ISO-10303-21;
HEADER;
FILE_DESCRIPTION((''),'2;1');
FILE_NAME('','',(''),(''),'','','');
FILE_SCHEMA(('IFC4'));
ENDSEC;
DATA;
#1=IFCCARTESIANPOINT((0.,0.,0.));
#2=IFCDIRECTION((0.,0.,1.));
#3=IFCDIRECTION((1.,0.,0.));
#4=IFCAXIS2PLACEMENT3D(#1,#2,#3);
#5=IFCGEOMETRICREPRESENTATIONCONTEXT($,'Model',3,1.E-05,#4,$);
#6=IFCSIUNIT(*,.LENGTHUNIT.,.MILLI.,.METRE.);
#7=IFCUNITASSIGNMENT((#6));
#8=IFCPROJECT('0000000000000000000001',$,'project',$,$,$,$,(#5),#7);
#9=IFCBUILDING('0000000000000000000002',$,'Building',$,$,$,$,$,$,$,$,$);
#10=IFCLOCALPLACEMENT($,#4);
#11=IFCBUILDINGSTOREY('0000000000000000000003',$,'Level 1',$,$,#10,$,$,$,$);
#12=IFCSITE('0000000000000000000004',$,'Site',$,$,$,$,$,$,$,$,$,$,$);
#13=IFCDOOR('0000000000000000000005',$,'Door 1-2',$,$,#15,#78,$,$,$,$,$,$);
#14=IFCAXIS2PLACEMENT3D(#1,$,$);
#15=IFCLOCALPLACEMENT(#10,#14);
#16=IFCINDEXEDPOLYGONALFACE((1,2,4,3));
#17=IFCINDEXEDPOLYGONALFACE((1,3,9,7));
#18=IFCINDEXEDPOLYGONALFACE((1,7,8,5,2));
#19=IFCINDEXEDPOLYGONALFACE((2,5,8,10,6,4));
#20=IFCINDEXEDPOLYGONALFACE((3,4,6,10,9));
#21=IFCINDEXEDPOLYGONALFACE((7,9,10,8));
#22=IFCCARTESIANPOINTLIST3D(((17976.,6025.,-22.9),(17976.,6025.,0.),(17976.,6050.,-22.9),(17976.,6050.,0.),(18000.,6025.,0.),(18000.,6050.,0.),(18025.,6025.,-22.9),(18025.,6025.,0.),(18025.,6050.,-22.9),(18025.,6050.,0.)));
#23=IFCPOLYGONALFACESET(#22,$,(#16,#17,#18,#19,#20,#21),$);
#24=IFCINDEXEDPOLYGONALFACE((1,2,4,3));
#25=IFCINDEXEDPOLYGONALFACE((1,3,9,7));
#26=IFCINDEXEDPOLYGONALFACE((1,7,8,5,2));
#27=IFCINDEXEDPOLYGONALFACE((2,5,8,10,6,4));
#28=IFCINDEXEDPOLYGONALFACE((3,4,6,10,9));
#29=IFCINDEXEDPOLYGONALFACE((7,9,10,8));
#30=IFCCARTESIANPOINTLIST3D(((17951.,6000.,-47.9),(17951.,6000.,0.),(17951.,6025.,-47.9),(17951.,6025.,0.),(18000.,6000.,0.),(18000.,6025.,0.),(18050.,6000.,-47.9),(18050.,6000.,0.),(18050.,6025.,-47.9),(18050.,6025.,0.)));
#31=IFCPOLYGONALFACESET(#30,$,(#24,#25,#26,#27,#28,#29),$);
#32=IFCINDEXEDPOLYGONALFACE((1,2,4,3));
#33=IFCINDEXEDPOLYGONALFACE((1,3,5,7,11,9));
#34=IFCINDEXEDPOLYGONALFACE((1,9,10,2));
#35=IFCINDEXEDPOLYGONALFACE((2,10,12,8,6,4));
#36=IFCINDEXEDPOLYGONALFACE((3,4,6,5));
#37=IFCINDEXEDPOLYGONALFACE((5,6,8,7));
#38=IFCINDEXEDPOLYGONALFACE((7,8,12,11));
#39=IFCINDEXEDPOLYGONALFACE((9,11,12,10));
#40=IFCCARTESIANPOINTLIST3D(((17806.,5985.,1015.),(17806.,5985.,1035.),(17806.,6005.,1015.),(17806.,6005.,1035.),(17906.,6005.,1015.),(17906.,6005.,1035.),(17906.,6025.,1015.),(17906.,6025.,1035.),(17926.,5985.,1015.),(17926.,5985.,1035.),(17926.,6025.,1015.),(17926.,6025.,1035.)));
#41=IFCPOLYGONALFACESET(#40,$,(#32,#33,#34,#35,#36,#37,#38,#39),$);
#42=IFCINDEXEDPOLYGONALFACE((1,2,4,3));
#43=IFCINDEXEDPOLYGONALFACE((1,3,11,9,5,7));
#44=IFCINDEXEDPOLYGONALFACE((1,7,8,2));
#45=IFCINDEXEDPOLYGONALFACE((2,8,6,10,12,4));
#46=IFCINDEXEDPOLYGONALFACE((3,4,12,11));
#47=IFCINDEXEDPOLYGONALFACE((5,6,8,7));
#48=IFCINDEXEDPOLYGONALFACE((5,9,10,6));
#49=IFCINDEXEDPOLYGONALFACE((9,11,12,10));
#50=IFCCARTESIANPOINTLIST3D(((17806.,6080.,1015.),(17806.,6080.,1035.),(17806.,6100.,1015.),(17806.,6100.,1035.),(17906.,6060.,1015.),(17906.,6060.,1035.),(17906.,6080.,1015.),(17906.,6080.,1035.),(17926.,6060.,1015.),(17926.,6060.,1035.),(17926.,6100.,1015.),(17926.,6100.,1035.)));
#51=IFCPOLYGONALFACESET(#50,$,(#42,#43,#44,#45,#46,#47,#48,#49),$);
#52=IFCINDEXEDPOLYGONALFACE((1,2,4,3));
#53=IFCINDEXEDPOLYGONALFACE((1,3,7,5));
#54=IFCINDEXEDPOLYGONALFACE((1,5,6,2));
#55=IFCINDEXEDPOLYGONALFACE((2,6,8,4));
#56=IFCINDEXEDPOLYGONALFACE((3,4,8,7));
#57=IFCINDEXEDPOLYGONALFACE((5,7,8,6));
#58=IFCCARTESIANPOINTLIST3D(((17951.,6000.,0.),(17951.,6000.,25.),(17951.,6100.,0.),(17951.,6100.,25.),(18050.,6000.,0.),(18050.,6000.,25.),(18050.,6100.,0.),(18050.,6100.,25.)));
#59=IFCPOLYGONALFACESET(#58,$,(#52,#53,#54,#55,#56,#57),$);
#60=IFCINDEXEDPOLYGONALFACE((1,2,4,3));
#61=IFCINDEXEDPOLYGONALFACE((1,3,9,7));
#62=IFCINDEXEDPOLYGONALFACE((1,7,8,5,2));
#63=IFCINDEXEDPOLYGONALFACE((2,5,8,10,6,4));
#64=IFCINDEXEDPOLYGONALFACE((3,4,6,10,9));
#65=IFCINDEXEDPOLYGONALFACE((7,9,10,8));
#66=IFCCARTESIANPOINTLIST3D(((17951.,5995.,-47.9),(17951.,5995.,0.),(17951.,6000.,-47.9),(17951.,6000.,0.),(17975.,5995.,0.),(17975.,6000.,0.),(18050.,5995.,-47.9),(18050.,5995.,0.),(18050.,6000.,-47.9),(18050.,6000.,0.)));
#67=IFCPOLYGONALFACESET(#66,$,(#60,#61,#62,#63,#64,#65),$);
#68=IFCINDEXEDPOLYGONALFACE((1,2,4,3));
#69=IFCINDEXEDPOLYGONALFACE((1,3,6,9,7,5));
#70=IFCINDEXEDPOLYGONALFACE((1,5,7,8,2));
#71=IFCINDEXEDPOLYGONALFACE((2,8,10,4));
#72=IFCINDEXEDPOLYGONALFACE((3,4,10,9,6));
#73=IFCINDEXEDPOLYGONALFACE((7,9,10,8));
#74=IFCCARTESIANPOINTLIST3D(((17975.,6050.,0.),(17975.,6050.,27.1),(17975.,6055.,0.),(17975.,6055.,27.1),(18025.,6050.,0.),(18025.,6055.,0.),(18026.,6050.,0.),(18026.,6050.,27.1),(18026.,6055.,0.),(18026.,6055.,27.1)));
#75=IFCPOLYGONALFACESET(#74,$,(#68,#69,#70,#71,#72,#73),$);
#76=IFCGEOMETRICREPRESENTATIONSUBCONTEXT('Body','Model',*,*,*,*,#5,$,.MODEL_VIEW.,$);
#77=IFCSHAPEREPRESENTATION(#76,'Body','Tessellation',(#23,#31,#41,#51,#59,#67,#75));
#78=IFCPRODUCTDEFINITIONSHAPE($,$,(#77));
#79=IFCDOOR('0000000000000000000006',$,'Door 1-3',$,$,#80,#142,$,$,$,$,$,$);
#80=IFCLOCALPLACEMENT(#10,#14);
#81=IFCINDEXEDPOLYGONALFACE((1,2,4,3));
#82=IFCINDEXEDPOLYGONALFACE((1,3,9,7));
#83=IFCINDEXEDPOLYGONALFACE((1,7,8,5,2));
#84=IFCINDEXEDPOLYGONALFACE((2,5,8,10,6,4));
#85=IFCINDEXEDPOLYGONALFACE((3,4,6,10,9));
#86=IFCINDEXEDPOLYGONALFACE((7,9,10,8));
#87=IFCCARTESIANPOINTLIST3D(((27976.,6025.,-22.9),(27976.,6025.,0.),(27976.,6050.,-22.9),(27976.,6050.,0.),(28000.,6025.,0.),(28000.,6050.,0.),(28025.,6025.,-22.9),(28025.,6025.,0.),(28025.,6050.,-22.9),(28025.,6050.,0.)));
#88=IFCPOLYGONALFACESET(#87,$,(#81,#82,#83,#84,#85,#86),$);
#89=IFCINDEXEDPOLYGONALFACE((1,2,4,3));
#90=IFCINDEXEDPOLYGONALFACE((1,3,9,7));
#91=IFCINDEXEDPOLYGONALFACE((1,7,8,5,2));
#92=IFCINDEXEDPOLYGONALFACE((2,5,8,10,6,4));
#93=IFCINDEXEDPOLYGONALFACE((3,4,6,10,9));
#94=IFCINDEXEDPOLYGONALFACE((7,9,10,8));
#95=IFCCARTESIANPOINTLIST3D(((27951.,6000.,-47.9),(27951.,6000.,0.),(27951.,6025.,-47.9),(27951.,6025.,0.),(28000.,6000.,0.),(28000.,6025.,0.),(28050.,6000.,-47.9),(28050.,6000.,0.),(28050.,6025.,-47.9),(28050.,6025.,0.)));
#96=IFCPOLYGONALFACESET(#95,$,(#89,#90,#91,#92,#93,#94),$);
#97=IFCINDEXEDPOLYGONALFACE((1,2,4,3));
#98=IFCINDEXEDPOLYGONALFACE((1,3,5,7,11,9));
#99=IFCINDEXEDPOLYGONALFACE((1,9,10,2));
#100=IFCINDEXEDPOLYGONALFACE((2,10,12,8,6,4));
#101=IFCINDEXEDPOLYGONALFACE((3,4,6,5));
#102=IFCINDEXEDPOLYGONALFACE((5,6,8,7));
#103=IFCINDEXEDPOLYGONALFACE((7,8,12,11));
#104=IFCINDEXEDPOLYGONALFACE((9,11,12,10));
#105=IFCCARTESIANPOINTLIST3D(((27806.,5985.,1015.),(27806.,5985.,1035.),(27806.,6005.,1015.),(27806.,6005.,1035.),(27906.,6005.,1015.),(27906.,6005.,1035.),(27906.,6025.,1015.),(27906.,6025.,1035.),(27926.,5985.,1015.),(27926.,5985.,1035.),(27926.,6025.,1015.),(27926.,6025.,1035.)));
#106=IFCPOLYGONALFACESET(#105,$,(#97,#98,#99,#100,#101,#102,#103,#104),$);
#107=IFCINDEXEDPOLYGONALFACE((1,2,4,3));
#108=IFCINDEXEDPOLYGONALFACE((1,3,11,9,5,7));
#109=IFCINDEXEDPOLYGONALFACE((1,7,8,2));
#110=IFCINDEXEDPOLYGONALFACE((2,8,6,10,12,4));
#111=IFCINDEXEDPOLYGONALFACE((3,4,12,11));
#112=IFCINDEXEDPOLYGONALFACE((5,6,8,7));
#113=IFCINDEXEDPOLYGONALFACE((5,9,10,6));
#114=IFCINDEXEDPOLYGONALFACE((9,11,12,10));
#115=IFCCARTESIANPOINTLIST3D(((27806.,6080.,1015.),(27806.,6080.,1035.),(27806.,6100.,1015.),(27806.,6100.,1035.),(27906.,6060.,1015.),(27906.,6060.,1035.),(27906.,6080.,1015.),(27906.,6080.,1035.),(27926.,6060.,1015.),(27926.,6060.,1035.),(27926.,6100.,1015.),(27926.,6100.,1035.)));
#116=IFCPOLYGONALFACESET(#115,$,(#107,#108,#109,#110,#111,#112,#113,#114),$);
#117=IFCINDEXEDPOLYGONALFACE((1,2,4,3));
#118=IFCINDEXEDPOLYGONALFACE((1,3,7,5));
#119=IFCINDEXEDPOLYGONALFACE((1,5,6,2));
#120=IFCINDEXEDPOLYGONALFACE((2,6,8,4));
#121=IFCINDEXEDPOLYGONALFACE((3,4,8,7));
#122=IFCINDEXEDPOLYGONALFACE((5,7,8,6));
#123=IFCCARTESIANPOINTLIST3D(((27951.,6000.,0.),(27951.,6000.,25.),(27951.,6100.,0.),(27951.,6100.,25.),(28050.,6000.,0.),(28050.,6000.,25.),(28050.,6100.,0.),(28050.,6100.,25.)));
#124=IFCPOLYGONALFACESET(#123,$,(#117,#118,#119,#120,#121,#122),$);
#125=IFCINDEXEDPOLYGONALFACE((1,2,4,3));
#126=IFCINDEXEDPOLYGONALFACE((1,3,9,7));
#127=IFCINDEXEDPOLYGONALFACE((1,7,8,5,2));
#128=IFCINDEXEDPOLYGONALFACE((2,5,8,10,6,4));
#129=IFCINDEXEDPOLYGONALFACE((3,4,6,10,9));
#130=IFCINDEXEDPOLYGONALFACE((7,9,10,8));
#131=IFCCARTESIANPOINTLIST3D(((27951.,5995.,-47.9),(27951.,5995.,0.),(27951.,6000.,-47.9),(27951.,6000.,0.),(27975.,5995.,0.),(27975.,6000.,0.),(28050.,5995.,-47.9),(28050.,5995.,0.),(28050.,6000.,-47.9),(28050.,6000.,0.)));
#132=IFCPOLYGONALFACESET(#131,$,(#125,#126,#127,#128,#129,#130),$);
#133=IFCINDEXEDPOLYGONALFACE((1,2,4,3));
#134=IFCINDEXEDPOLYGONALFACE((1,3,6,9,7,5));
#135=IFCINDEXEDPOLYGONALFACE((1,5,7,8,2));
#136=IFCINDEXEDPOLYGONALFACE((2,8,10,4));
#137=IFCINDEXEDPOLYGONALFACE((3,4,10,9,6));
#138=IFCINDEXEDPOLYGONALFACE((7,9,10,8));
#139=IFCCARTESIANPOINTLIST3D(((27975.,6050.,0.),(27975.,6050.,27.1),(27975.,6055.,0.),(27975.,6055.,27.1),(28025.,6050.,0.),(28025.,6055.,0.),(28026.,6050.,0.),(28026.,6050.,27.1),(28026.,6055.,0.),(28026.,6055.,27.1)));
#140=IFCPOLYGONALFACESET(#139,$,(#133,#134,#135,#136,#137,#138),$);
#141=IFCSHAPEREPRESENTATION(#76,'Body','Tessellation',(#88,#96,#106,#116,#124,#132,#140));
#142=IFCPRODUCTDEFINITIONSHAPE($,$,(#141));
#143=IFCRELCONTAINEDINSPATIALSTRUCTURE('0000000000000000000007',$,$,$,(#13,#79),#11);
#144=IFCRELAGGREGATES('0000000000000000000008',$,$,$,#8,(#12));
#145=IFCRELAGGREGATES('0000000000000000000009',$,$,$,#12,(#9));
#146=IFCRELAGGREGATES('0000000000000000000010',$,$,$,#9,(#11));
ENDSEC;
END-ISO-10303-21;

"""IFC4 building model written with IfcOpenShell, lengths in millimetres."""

from ifc_helpers import new_model, si_unit, frame, origin_with_axes, place, context, subcontext, project, spatial, line, indexed_curve, outline, extrude, element, save


model = new_model("IFC4")

# Units and contexts
model_context = context("Model", 3, precision=1e-05, world=origin_with_axes())
body_context = subcontext(model_context, "Body", "Model", "MODEL_VIEW")
ifc_project = project(units=[si_unit("LENGTHUNIT", "METRE", prefix="MILLI")], contexts=[model_context])

# Site, building, storey
site = spatial("IfcSite", under=ifc_project, Name="Site")
building = spatial("IfcBuilding", under=site, Name="Building")
storey_placement = place(None, origin_with_axes())
storey = spatial("IfcBuildingStorey", under=building, at=storey_placement, Name="Level 1")

# Doors
door_1_placement = place(storey_placement, frame((18000.0, 6000.0, 0.0), z_axis=(0.0, 0.0, 1.0), x_axis=(1.0, 0.0, 0.0)))
element("IfcDoor", 1, at=door_1_placement, inside=storey, Name="Door 1-2", context=body_context, shape_type="SweptSolid", body=[
    extrude(outline(indexed_curve([(0.0, 0.0), (0.0, 2.1), (1.0, 2.1), (1.0, 0.0), (-24.0, 0.0), (-24.0, -22.9), (25.0, -22.9), (25.0, 0.0)], segments=[line(1, 2, 3, 4, 5, 6, 7, 8, 1)])), frame((0.0, 25.0, 0.0), z_axis=(0.0, -1.0, 0.0), x_axis=(1.0, 0.0, 0.0)), (0.0, 0.0, -1.0), 25.0),
    extrude(outline(indexed_curve([(0.0, 0.0), (0.0, 2.1), (1.0, 2.1), (1.0, 0.0), (-49.0, 0.0), (-49.0, -47.9), (50.0, -47.9), (50.0, 0.0)], segments=[line(1, 2, 3, 4, 5, 6, 7, 8, 1)])), frame((0.0, 0.0, 0.0), z_axis=(0.0, -1.0, 0.0), x_axis=(1.0, 0.0, 0.0)), (0.0, 0.0, -1.0), 25.0),
    extrude(outline(indexed_curve([(0.0, 0.0), (-49.0, 0.0), (-49.0, 35.0), (0.0, 35.0)], segments=[line(1, 2, 3, 4, 1)])), frame((25.0, 25.0, 25.0), z_axis=(0.0, 0.0, 1.0), x_axis=(1.0, 0.0, 0.0)), (0.0, 0.0, 1.0), -47.9),
    extrude(outline(indexed_curve([(0.0, 0.0), (0.0, -40.0), (-120.0, -40.0), (-120.0, -20.0), (-20.0, -20.0), (-20.0, 0.0)], segments=[line(1, 2, 3, 4, 5, 6, 1)])), frame((-74.0, 25.0, 1015.0), z_axis=(0.0, 0.0, 1.0), x_axis=(1.0, 0.0, 0.0)), (0.0, 0.0, 1.0), 20.0),
    extrude(outline(indexed_curve([(0.0, 0.0), (0.0, 40.0), (-120.0, 40.0), (-120.0, 20.0), (-20.0, 20.0), (-20.0, 0.0)], segments=[line(1, 2, 3, 4, 5, 6, 1)])), frame((-74.0, 60.0, 1015.0), z_axis=(0.0, 0.0, 1.0), x_axis=(1.0, 0.0, 0.0)), (0.0, 0.0, 1.0), 20.0),
    extrude(outline(indexed_curve([(0.0, 0.0), (-99.0, 0.0), (-99.0, 100.0), (0.0, 100.0)], segments=[line(1, 2, 3, 4, 1)])), frame((50.0, 0.0, 0.0), z_axis=(0.0, 0.0, 1.0), x_axis=(1.0, 0.0, 0.0)), (0.0, 0.0, 1.0), 25.0),
    extrude(outline(indexed_curve([(0.0, 0.0), (0.0, 27.1), (51.0, 27.1), (51.0, 0.0), (-24.0, 0.0), (-24.0, -47.9), (75.0, -47.9), (75.0, 0.0)], segments=[line(1, 2, 3, 4, 5, 6, 7, 8, 1)])), frame((-25.0, -5.0, 0.0), z_axis=(0.0, -1.0, 0.0), x_axis=(1.0, 0.0, 0.0)), (0.0, 0.0, -1.0), 5.0),
    extrude(outline(indexed_curve([(0.0, 0.0), (0.0, 27.1), (51.0, 27.1), (51.0, 0.0), (1.0, 0.0), (1.0, -22.9), (50.0, -22.9), (50.0, 0.0)], segments=[line(1, 2, 3, 4, 5, 6, 7, 8, 1)])), frame((-25.0, 50.0, 0.0), z_axis=(0.0, -1.0, 0.0), x_axis=(1.0, 0.0, 0.0)), (0.0, 0.0, -1.0), 5.0),
])
door_2_placement = place(storey_placement, frame((28000.0, 6000.0, 0.0), z_axis=(0.0, 0.0, 1.0), x_axis=(1.0, 0.0, 0.0)))
element("IfcDoor", 2, at=door_2_placement, inside=storey, Name="Door 1-3", context=body_context, shape_type="SweptSolid", body=[
    extrude(outline(indexed_curve([(0.0, 0.0), (0.0, 2.1), (1.0, 2.1), (1.0, 0.0), (-24.0, 0.0), (-24.0, -22.9), (25.0, -22.9), (25.0, 0.0)], segments=[line(1, 2, 3, 4, 5, 6, 7, 8, 1)])), frame((0.0, 25.0, 0.0), z_axis=(0.0, -1.0, 0.0), x_axis=(1.0, 0.0, 0.0)), (0.0, 0.0, -1.0), 25.0),
    extrude(outline(indexed_curve([(0.0, 0.0), (0.0, 2.1), (1.0, 2.1), (1.0, 0.0), (-49.0, 0.0), (-49.0, -47.9), (50.0, -47.9), (50.0, 0.0)], segments=[line(1, 2, 3, 4, 5, 6, 7, 8, 1)])), frame((0.0, 0.0, 0.0), z_axis=(0.0, -1.0, 0.0), x_axis=(1.0, 0.0, 0.0)), (0.0, 0.0, -1.0), 25.0),
    extrude(outline(indexed_curve([(0.0, 0.0), (-49.0, 0.0), (-49.0, 35.0), (0.0, 35.0)], segments=[line(1, 2, 3, 4, 1)])), frame((25.0, 25.0, 25.0), z_axis=(0.0, 0.0, 1.0), x_axis=(1.0, 0.0, 0.0)), (0.0, 0.0, 1.0), -47.9),
    extrude(outline(indexed_curve([(0.0, 0.0), (0.0, -40.0), (-120.0, -40.0), (-120.0, -20.0), (-20.0, -20.0), (-20.0, 0.0)], segments=[line(1, 2, 3, 4, 5, 6, 1)])), frame((-74.0, 25.0, 1015.0), z_axis=(0.0, 0.0, 1.0), x_axis=(1.0, 0.0, 0.0)), (0.0, 0.0, 1.0), 20.0),
    extrude(outline(indexed_curve([(0.0, 0.0), (0.0, 40.0), (-120.0, 40.0), (-120.0, 20.0), (-20.0, 20.0), (-20.0, 0.0)], segments=[line(1, 2, 3, 4, 5, 6, 1)])), frame((-74.0, 60.0, 1015.0), z_axis=(0.0, 0.0, 1.0), x_axis=(1.0, 0.0, 0.0)), (0.0, 0.0, 1.0), 20.0),
    extrude(outline(indexed_curve([(0.0, 0.0), (-99.0, 0.0), (-99.0, 100.0), (0.0, 100.0)], segments=[line(1, 2, 3, 4, 1)])), frame((50.0, 0.0, 0.0), z_axis=(0.0, 0.0, 1.0), x_axis=(1.0, 0.0, 0.0)), (0.0, 0.0, 1.0), 25.0),
    extrude(outline(indexed_curve([(0.0, 0.0), (0.0, 27.1), (51.0, 27.1), (51.0, 0.0), (-24.0, 0.0), (-24.0, -47.9), (75.0, -47.9), (75.0, 0.0)], segments=[line(1, 2, 3, 4, 5, 6, 7, 8, 1)])), frame((-25.0, -5.0, 0.0), z_axis=(0.0, -1.0, 0.0), x_axis=(1.0, 0.0, 0.0)), (0.0, 0.0, -1.0), 5.0),
    extrude(outline(indexed_curve([(0.0, 0.0), (0.0, 27.1), (51.0, 27.1), (51.0, 0.0), (1.0, 0.0), (1.0, -22.9), (50.0, -22.9), (50.0, 0.0)], segments=[line(1, 2, 3, 4, 5, 6, 7, 8, 1)])), frame((-25.0, 50.0, 0.0), z_axis=(0.0, -1.0, 0.0), x_axis=(1.0, 0.0, 0.0)), (0.0, 0.0, -1.0), 5.0),
])

save(model, "model.ifc")
